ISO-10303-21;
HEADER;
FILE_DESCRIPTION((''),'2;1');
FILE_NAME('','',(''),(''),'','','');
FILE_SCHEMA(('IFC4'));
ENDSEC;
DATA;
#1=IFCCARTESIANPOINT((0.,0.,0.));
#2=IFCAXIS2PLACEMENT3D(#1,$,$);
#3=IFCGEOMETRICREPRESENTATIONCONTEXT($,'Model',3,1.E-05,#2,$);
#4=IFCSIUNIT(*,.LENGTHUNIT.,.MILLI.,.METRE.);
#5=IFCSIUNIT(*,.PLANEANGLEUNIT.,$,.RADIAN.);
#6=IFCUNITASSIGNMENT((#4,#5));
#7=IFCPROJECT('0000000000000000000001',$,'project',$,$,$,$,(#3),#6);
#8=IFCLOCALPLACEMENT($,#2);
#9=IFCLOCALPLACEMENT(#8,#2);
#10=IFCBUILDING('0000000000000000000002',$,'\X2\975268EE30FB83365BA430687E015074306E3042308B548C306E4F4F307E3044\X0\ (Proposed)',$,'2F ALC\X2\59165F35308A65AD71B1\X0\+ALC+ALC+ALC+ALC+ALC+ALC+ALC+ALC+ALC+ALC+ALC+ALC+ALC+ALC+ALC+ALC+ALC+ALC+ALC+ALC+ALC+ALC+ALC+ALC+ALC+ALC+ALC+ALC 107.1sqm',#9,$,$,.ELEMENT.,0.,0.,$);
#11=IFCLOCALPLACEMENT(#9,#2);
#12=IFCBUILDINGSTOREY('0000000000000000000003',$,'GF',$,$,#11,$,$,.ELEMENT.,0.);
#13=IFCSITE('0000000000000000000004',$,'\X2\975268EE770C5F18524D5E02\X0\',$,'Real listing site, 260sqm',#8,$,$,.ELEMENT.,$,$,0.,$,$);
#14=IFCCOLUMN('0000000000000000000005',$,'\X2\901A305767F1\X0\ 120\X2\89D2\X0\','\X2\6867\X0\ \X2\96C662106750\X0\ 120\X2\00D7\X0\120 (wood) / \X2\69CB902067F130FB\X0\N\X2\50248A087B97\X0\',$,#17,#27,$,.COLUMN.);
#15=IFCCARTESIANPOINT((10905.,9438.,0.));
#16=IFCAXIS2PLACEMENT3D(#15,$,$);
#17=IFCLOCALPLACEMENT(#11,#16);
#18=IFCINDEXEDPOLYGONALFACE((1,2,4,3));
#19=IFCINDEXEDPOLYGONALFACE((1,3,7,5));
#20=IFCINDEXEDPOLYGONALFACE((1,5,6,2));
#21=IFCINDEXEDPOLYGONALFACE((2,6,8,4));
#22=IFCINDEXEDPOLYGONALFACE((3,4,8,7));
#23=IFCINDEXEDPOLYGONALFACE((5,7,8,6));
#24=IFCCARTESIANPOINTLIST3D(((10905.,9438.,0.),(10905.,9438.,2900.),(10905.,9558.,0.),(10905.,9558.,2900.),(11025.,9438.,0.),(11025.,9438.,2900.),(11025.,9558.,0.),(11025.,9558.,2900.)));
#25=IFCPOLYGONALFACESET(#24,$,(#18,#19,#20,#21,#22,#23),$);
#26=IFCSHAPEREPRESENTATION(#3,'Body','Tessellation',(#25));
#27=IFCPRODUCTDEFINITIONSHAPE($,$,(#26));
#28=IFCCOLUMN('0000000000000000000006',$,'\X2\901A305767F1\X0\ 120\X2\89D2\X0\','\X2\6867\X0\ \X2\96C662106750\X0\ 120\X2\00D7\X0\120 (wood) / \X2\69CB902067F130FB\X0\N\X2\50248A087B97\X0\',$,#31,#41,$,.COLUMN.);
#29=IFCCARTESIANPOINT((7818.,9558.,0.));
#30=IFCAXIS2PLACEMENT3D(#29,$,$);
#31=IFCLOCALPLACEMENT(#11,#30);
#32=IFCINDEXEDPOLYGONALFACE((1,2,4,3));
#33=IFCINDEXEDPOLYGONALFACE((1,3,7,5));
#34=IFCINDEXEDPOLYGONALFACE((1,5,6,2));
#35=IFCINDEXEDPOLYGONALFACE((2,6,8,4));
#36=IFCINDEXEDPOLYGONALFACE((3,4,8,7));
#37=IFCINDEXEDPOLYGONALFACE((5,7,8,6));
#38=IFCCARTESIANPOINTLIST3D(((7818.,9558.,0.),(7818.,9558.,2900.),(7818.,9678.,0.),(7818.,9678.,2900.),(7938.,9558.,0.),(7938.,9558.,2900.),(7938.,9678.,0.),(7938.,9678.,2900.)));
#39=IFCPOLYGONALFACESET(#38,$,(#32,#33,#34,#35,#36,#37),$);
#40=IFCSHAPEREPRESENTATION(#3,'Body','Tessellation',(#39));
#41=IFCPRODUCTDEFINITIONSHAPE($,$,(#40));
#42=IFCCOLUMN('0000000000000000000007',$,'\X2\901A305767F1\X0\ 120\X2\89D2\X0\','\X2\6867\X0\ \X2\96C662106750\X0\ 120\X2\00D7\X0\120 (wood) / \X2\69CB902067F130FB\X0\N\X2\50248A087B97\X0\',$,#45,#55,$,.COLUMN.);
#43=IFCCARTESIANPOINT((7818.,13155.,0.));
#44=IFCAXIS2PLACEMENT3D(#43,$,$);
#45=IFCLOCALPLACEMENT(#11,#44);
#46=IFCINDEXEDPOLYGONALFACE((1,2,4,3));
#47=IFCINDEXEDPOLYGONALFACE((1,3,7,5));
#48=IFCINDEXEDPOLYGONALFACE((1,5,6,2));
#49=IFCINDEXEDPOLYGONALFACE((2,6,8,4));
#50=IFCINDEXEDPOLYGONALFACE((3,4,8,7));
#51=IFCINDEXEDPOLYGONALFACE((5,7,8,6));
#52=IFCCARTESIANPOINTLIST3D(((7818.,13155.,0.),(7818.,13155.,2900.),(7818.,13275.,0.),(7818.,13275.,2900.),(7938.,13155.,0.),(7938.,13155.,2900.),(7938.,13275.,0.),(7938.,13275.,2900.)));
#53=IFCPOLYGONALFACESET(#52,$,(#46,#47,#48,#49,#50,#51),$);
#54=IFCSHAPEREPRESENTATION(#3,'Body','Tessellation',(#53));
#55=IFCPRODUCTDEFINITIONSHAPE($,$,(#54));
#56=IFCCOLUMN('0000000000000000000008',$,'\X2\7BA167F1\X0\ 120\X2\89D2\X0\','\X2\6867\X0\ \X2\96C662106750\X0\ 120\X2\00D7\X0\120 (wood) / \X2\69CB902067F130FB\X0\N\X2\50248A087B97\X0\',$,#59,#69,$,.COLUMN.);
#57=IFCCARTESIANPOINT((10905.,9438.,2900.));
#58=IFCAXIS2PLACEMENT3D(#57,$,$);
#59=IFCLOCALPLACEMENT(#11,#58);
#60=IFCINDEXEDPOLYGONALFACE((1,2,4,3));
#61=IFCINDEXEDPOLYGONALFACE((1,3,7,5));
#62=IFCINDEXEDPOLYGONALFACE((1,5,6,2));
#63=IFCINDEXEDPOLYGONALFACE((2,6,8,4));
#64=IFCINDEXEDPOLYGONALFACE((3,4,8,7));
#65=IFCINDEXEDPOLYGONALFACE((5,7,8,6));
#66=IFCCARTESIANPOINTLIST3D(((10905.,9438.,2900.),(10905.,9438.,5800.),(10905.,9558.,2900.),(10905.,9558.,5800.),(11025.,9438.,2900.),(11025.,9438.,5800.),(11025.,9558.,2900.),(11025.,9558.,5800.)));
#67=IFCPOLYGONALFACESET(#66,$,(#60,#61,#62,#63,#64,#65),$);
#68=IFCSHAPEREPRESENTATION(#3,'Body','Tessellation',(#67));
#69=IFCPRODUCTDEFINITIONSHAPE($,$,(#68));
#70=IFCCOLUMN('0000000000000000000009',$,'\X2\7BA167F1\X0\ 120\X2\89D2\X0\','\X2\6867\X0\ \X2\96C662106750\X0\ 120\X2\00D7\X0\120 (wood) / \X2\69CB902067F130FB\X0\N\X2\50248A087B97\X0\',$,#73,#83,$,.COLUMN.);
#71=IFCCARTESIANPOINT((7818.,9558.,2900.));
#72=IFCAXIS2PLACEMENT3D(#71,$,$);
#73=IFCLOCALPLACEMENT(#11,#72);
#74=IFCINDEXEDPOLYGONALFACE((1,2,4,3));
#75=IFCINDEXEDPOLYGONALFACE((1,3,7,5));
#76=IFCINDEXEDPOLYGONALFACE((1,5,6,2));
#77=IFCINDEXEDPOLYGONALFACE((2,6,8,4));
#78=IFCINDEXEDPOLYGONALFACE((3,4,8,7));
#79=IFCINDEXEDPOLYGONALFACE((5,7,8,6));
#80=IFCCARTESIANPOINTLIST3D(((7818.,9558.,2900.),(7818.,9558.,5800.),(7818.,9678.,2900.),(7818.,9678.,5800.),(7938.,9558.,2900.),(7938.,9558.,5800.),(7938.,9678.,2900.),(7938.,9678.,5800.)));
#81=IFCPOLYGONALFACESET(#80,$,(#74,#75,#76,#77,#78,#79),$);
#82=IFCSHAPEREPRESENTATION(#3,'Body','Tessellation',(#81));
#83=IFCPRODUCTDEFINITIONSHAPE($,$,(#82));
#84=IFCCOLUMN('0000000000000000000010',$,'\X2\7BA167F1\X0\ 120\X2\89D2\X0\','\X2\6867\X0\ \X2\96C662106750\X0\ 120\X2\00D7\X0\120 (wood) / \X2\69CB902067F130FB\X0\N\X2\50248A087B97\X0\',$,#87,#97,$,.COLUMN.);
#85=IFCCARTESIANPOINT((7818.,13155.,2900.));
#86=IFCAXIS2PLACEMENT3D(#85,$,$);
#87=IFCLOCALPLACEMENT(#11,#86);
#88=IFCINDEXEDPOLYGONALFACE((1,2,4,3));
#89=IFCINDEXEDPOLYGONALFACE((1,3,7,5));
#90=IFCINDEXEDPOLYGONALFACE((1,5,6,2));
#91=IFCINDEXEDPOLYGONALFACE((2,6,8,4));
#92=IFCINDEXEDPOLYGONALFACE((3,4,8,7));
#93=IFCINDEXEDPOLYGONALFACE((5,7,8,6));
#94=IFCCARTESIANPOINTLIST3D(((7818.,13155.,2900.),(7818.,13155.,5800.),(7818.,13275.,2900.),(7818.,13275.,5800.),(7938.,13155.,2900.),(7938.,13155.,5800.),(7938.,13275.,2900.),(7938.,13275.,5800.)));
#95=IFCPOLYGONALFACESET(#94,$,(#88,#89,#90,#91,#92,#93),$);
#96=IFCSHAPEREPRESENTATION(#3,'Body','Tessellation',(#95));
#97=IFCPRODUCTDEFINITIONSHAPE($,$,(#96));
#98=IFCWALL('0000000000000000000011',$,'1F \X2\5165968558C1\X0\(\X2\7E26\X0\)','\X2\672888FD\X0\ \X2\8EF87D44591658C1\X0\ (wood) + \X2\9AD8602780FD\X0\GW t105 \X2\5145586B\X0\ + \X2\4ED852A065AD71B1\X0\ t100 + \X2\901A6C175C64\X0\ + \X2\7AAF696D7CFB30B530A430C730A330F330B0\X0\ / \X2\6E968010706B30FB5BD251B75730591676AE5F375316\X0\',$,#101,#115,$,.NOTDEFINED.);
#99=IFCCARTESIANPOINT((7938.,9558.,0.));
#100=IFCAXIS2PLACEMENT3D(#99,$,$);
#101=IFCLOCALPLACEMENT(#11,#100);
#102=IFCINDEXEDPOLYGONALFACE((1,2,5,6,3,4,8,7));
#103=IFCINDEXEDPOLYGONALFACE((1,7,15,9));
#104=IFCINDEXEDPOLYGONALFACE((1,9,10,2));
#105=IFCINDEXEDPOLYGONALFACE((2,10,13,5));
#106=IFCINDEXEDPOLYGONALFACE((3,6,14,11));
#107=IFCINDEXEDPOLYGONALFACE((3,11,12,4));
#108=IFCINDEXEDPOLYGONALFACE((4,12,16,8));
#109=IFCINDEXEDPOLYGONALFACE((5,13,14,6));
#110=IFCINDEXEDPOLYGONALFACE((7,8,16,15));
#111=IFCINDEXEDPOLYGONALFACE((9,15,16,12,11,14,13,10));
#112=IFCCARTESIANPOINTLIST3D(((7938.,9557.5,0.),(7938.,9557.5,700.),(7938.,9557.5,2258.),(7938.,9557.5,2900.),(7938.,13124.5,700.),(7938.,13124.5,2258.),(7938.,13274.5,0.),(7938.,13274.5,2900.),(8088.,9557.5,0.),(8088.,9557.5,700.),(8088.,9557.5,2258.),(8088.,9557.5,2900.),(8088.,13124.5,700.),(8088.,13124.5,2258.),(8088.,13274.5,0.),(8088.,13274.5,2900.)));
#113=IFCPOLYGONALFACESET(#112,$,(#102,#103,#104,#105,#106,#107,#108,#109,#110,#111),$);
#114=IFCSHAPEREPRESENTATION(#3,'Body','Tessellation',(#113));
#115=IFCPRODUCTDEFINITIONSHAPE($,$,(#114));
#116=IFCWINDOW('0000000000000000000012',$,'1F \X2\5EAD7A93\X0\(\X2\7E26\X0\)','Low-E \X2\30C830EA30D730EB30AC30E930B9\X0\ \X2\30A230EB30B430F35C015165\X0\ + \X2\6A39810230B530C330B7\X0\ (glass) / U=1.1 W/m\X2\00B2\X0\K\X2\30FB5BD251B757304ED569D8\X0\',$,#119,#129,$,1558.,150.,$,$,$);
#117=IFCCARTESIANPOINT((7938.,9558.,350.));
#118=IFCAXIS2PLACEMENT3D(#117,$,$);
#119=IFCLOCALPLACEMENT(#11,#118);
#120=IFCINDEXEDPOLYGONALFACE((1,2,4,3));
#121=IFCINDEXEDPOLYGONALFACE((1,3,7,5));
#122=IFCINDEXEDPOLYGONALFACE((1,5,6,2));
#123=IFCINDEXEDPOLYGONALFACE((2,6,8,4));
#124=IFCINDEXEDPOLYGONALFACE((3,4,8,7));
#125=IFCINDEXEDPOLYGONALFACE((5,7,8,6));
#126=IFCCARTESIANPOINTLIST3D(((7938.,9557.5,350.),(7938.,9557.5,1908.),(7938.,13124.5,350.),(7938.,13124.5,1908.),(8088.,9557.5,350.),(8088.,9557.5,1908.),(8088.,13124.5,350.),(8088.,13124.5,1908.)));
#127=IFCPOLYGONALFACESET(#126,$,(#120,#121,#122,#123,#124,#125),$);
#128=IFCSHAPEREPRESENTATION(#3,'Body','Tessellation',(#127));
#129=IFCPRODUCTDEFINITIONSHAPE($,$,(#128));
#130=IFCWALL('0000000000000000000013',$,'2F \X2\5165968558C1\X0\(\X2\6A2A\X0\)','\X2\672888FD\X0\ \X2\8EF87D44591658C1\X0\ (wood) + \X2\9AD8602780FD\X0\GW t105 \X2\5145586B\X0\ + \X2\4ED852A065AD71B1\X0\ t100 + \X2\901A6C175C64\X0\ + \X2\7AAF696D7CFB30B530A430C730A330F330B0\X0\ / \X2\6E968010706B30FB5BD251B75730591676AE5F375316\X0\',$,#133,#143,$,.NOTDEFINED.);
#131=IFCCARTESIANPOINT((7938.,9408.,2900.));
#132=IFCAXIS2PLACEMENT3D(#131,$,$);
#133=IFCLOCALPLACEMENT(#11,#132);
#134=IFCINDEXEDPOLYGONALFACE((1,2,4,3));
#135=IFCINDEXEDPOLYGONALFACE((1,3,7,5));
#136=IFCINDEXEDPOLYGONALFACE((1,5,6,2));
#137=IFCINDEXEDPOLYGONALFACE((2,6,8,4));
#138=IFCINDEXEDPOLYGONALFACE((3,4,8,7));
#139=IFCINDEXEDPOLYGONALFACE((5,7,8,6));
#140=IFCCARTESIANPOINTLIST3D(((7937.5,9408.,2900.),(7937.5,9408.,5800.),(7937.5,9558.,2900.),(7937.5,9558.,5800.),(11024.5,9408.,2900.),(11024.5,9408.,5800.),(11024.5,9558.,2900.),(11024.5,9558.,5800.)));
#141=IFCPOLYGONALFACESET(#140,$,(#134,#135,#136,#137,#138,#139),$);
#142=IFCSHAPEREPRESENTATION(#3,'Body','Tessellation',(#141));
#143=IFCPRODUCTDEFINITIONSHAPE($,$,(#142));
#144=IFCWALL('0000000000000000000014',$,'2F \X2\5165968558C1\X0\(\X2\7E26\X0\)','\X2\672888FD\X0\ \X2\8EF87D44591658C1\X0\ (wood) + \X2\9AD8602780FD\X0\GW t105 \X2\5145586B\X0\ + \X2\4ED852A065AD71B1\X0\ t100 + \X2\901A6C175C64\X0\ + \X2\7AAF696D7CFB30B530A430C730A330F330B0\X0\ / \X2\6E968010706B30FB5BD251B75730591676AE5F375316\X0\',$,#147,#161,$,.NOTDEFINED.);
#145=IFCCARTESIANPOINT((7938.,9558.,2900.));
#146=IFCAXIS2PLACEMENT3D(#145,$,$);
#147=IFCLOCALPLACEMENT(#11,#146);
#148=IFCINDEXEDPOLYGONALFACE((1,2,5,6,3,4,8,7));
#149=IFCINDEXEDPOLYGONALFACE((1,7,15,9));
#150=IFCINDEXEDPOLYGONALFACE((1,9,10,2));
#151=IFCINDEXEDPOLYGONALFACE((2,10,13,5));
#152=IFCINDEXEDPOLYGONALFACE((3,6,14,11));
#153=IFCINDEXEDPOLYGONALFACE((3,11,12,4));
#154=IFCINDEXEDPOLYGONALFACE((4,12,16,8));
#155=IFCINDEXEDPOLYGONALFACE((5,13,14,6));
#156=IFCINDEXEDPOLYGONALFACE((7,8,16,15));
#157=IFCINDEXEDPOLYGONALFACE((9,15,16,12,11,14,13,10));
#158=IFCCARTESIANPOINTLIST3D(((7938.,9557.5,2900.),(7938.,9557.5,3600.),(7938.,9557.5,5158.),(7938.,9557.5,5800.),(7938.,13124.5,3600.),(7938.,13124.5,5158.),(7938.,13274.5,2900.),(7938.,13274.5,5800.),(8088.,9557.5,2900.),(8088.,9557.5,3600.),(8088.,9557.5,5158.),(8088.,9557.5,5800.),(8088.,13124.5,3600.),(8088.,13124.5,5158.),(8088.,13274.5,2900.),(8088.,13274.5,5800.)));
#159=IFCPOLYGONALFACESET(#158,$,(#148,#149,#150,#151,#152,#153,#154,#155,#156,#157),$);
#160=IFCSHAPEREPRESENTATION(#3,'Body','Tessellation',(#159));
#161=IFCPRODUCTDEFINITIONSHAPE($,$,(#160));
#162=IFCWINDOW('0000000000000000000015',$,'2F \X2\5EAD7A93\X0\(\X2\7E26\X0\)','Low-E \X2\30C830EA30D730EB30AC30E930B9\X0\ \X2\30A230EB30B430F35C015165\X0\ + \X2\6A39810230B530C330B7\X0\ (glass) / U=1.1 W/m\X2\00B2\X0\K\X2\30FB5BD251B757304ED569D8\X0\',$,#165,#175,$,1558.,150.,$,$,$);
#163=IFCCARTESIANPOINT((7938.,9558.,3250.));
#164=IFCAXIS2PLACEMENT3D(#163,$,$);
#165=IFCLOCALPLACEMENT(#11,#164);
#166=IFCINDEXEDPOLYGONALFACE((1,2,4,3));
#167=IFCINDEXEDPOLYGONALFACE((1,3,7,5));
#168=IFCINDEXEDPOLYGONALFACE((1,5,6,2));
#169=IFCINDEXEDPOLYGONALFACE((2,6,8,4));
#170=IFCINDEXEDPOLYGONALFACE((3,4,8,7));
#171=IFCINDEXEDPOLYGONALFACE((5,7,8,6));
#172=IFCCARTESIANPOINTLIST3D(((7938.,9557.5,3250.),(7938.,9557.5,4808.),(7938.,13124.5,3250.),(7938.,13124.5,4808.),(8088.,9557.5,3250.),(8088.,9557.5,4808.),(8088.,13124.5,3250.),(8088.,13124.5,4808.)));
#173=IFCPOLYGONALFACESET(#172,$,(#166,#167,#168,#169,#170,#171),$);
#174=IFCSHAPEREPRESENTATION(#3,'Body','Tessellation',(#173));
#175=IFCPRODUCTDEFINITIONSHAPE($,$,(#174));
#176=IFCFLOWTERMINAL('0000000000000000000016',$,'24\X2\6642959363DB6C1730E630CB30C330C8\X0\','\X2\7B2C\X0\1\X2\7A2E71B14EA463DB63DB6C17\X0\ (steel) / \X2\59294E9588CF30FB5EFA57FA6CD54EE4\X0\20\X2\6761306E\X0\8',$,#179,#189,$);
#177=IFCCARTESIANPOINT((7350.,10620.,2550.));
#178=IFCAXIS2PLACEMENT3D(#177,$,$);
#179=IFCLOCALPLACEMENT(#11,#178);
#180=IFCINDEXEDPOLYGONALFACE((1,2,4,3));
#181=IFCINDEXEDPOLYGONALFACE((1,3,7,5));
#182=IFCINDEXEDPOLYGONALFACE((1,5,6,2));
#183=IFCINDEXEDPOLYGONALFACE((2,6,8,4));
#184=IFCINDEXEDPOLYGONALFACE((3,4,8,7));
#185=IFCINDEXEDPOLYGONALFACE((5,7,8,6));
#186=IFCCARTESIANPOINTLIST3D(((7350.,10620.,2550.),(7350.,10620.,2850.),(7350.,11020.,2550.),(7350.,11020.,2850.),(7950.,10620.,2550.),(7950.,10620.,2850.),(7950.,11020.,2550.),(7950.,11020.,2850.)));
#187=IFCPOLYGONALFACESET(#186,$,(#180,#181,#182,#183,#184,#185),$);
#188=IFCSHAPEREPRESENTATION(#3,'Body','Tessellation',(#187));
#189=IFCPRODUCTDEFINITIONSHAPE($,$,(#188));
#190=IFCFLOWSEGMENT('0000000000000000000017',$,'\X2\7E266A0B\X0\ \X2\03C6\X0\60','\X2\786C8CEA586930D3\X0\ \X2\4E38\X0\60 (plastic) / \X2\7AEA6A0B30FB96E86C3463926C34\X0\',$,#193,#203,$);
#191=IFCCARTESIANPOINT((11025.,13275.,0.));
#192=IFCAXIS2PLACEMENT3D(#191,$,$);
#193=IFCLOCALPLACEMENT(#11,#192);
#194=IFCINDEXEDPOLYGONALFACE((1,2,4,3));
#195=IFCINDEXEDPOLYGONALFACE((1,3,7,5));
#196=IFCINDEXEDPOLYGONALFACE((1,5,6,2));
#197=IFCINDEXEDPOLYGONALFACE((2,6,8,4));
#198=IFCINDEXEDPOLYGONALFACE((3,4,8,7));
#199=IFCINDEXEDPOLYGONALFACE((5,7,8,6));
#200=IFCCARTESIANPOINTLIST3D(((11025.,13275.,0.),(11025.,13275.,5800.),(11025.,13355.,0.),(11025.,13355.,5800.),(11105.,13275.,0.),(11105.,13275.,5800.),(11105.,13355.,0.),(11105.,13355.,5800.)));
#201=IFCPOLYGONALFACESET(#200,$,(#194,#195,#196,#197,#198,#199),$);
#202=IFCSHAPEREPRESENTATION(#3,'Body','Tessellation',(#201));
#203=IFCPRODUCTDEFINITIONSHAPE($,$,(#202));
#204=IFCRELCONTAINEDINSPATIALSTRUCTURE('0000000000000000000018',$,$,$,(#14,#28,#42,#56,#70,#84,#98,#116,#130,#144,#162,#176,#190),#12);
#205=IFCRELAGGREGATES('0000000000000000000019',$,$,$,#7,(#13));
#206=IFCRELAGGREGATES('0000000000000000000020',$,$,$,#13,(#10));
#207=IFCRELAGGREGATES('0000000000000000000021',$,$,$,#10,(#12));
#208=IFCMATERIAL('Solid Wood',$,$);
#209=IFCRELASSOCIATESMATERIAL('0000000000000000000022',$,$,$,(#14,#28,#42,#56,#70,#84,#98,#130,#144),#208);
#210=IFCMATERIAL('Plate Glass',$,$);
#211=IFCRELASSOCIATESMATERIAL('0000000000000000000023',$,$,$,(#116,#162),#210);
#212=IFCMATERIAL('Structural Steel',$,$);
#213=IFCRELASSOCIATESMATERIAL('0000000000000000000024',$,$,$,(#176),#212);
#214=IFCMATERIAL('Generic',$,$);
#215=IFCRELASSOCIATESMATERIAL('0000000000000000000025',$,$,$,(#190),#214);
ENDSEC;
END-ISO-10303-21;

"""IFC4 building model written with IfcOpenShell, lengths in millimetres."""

from ifc_helpers import new_model, si_unit, frame, frame_2d, origin, place, context, project, spatial, rectangle, extrude, material, element, fill, save


model = new_model("IFC4")

# Units and contexts
model_context = context("Model", 3, precision=1e-05, world=origin())
ifc_project = project(units=[si_unit("LENGTHUNIT", "METRE", prefix="MILLI"), si_unit("PLANEANGLEUNIT", "RADIAN")], contexts=[model_context])

# Site, building, storey
site_placement = place(None, origin())
site = spatial("IfcSite", under=ifc_project, at=site_placement, Name="青森県弘前市", ObjectType="Real listing site, 260sqm", CompositionType="ELEMENT", RefElevation=0.0)
building_placement = place(site_placement, origin())
building = spatial("IfcBuilding", under=site, at=building_placement, Name="青森・茶室と縁側のある和の住まい (Proposed)", ObjectType="2F ALC外張り断熱+ALC+ALC+ALC+ALC+ALC+ALC+ALC+ALC+ALC+ALC+ALC+ALC+ALC+ALC+ALC+ALC+ALC+ALC+ALC+ALC+ALC+ALC+ALC+ALC+ALC+ALC+ALC+ALC 107.1sqm", CompositionType="ELEMENT", ElevationOfRefHeight=0.0, ElevationOfTerrain=0.0)
storey_placement = place(building_placement, origin())
storey = spatial("IfcBuildingStorey", under=building, at=storey_placement, Name="GF", CompositionType="ELEMENT", Elevation=0.0)

# Columns
ifc_material_1 = material(Name="Solid Wood")
column_1_placement = place(storey_placement, frame((10905.0, 9438.0, 0.0)))
element("IfcColumn", 1, at=column_1_placement, inside=storey, material=ifc_material_1, Name="通し柱 120角", Description="桧 集成材 120×120 (wood) / 構造柱・N値計算", PredefinedType="COLUMN", context=model_context, shape_type="SweptSolid", body=[
    extrude(rectangle(XDim=120.0, YDim=120.0, at=frame_2d((60.0, 60.0))), frame((10905.0, 9438.0, 0.0)), (0.0, 0.0, 1.0), 2900.0),
])
column_2_placement = place(storey_placement, frame((7818.0, 9558.0, 0.0)))
element("IfcColumn", 2, at=column_2_placement, inside=storey, material=ifc_material_1, Name="通し柱 120角", Description="桧 集成材 120×120 (wood) / 構造柱・N値計算", PredefinedType="COLUMN", context=model_context, shape_type="SweptSolid", body=[
    extrude(rectangle(XDim=120.0, YDim=120.0, at=frame_2d((60.0, 60.0))), frame((7818.0, 9558.0, 0.0)), (0.0, 0.0, 1.0), 2900.0),
])
column_3_placement = place(storey_placement, frame((7818.0, 13155.0, 0.0)))
element("IfcColumn", 3, at=column_3_placement, inside=storey, material=ifc_material_1, Name="通し柱 120角", Description="桧 集成材 120×120 (wood) / 構造柱・N値計算", PredefinedType="COLUMN", context=model_context, shape_type="SweptSolid", body=[
    extrude(rectangle(XDim=120.0, YDim=120.0, at=frame_2d((60.0, 60.0))), frame((7818.0, 13155.0, 0.0)), (0.0, 0.0, 1.0), 2900.0),
])
column_4_placement = place(storey_placement, frame((10905.0, 9438.0, 2900.0)))
element("IfcColumn", 4, at=column_4_placement, inside=storey, material=ifc_material_1, Name="管柱 120角", Description="桧 集成材 120×120 (wood) / 構造柱・N値計算", PredefinedType="COLUMN", context=model_context, shape_type="SweptSolid", body=[
    extrude(rectangle(XDim=120.0, YDim=120.0, at=frame_2d((60.0, 60.0))), frame((10905.0, 9438.0, 2900.0)), (0.0, 0.0, 1.0), 2900.0),
])
column_5_placement = place(storey_placement, frame((7818.0, 9558.0, 2900.0)))
element("IfcColumn", 5, at=column_5_placement, inside=storey, material=ifc_material_1, Name="管柱 120角", Description="桧 集成材 120×120 (wood) / 構造柱・N値計算", PredefinedType="COLUMN", context=model_context, shape_type="SweptSolid", body=[
    extrude(rectangle(XDim=120.0, YDim=120.0, at=frame_2d((60.0, 60.0))), frame((7818.0, 9558.0, 2900.0)), (0.0, 0.0, 1.0), 2900.0),
])
column_6_placement = place(storey_placement, frame((7818.0, 13155.0, 2900.0)))
element("IfcColumn", 6, at=column_6_placement, inside=storey, material=ifc_material_1, Name="管柱 120角", Description="桧 集成材 120×120 (wood) / 構造柱・N値計算", PredefinedType="COLUMN", context=model_context, shape_type="SweptSolid", body=[
    extrude(rectangle(XDim=120.0, YDim=120.0, at=frame_2d((60.0, 60.0))), frame((7818.0, 13155.0, 2900.0)), (0.0, 0.0, 1.0), 2900.0),
])

# Wall, opening, window
wall_1_placement = place(storey_placement, frame((7938.0, 9558.0, 0.0)))
wall_1 = element("IfcWall", 7, at=wall_1_placement, inside=storey, material=ifc_material_1, Name="1F 入隅壁(縦)", Description="木製 軸組外壁 (wood) + 高性能GW t105 充填 + 付加断熱 t100 + 通気層 + 窯業系サイディング / 準耐火・寒冷地外皮強化", PredefinedType="NOTDEFINED", context=model_context, shape_type="SweptSolid", body=[
    extrude(rectangle(XDim=150.0, YDim=3717.0, at=frame_2d((75.0, 1858.0))), frame((7938.0, 9558.0, 0.0)), (0.0, 0.0, 1.0), 2900.0),
])
opening_1_placement = place(storey_placement, frame((7938.0, 9558.0, 350.0)))
opening_1 = element("IfcOpeningElement", 8, at=opening_1_placement, cuts=wall_1, PredefinedType="NOTDEFINED", context=model_context, shape_type="SweptSolid", body=[
    extrude(rectangle(XDim=150.0, YDim=3567.0, at=frame_2d((75.0, 1783.0))), frame((7938.0, 9558.0, 350.0)), (0.0, 0.0, 1.0), 1558.0),
])
ifc_material_2 = material(Name="Plate Glass")
window_1_placement = place(storey_placement, frame((7938.0, 9558.0, 350.0)))
window_1 = element("IfcWindow", 9, at=window_1_placement, inside=storey, material=ifc_material_2, Name="1F 庭窓(縦)", Description="Low-E トリプルガラス アルゴン封入 + 樹脂サッシ (glass) / U=1.1 W/m²K・寒冷地仕様", OverallHeight=1558.0, OverallWidth=150.0, context=model_context, shape_type="SweptSolid", body=[
    extrude(rectangle(XDim=150.0, YDim=3567.0, at=frame_2d((75.0, 1783.0))), frame((7938.0, 9558.0, 350.0)), (0.0, 0.0, 1.0), 1558.0),
])
fill(opening_1, window_1)

# Wall
wall_2_placement = place(storey_placement, frame((7938.0, 9408.0, 2900.0)))
element("IfcWall", 10, at=wall_2_placement, inside=storey, material=ifc_material_1, Name="2F 入隅壁(横)", Description="木製 軸組外壁 (wood) + 高性能GW t105 充填 + 付加断熱 t100 + 通気層 + 窯業系サイディング / 準耐火・寒冷地外皮強化", PredefinedType="NOTDEFINED", context=model_context, shape_type="SweptSolid", body=[
    extrude(rectangle(XDim=3087.0, YDim=150.0, at=frame_2d((1543.0, 75.0))), frame((7938.0, 9408.0, 2900.0)), (0.0, 0.0, 1.0), 2900.0),
])

# Wall, opening, window
wall_3_placement = place(storey_placement, frame((7938.0, 9558.0, 2900.0)))
wall_3 = element("IfcWall", 11, at=wall_3_placement, inside=storey, material=ifc_material_1, Name="2F 入隅壁(縦)", Description="木製 軸組外壁 (wood) + 高性能GW t105 充填 + 付加断熱 t100 + 通気層 + 窯業系サイディング / 準耐火・寒冷地外皮強化", PredefinedType="NOTDEFINED", context=model_context, shape_type="SweptSolid", body=[
    extrude(rectangle(XDim=150.0, YDim=3717.0, at=frame_2d((75.0, 1858.0))), frame((7938.0, 9558.0, 2900.0)), (0.0, 0.0, 1.0), 2900.0),
])
opening_2_placement = place(storey_placement, frame((7938.0, 9558.0, 3250.0)))
opening_2 = element("IfcOpeningElement", 12, at=opening_2_placement, cuts=wall_3, PredefinedType="NOTDEFINED", context=model_context, shape_type="SweptSolid", body=[
    extrude(rectangle(XDim=150.0, YDim=3567.0, at=frame_2d((75.0, 1783.0))), frame((7938.0, 9558.0, 3250.0)), (0.0, 0.0, 1.0), 1558.0),
])
window_2_placement = place(storey_placement, frame((7938.0, 9558.0, 3250.0)))
window_2 = element("IfcWindow", 13, at=window_2_placement, inside=storey, material=ifc_material_2, Name="2F 庭窓(縦)", Description="Low-E トリプルガラス アルゴン封入 + 樹脂サッシ (glass) / U=1.1 W/m²K・寒冷地仕様", OverallHeight=1558.0, OverallWidth=150.0, context=model_context, shape_type="SweptSolid", body=[
    extrude(rectangle(XDim=150.0, YDim=3567.0, at=frame_2d((75.0, 1783.0))), frame((7938.0, 9558.0, 3250.0)), (0.0, 0.0, 1.0), 1558.0),
])
fill(opening_2, window_2)

# Flow terminal
ifc_material_3 = material(Name="Structural Steel")
flow_terminal_placement = place(storey_placement, frame((7350.0, 10620.0, 2550.0)))
element("IfcFlowTerminal", 14, at=flow_terminal_placement, inside=storey, material=ifc_material_3, Name="24時間換気ユニット", Description="第1種熱交換換気 (steel) / 天井裏・建基法令20条の8", context=model_context, shape_type="SweptSolid", body=[
    extrude(rectangle(XDim=600.0, YDim=400.0, at=frame_2d((300.0, 200.0))), frame((7350.0, 10620.0, 2550.0)), (0.0, 0.0, 1.0), 300.0),
])

# Flow segment
ifc_material_4 = material(Name="Generic")
flow_segment_placement = place(storey_placement, frame((11025.0, 13275.0, 0.0)))
element("IfcFlowSegment", 15, at=flow_segment_placement, inside=storey, material=ifc_material_4, Name="縦樋 φ60", Description="硬質塩ビ 丸60 (plastic) / 竪樋・雨水排水", context=model_context, shape_type="SweptSolid", body=[
    extrude(rectangle(XDim=80.0, YDim=80.0, at=frame_2d((40.0, 40.0))), frame((11025.0, 13275.0, 0.0)), (0.0, 0.0, 1.0), 5800.0),
])

save(model, "model.ifc")
